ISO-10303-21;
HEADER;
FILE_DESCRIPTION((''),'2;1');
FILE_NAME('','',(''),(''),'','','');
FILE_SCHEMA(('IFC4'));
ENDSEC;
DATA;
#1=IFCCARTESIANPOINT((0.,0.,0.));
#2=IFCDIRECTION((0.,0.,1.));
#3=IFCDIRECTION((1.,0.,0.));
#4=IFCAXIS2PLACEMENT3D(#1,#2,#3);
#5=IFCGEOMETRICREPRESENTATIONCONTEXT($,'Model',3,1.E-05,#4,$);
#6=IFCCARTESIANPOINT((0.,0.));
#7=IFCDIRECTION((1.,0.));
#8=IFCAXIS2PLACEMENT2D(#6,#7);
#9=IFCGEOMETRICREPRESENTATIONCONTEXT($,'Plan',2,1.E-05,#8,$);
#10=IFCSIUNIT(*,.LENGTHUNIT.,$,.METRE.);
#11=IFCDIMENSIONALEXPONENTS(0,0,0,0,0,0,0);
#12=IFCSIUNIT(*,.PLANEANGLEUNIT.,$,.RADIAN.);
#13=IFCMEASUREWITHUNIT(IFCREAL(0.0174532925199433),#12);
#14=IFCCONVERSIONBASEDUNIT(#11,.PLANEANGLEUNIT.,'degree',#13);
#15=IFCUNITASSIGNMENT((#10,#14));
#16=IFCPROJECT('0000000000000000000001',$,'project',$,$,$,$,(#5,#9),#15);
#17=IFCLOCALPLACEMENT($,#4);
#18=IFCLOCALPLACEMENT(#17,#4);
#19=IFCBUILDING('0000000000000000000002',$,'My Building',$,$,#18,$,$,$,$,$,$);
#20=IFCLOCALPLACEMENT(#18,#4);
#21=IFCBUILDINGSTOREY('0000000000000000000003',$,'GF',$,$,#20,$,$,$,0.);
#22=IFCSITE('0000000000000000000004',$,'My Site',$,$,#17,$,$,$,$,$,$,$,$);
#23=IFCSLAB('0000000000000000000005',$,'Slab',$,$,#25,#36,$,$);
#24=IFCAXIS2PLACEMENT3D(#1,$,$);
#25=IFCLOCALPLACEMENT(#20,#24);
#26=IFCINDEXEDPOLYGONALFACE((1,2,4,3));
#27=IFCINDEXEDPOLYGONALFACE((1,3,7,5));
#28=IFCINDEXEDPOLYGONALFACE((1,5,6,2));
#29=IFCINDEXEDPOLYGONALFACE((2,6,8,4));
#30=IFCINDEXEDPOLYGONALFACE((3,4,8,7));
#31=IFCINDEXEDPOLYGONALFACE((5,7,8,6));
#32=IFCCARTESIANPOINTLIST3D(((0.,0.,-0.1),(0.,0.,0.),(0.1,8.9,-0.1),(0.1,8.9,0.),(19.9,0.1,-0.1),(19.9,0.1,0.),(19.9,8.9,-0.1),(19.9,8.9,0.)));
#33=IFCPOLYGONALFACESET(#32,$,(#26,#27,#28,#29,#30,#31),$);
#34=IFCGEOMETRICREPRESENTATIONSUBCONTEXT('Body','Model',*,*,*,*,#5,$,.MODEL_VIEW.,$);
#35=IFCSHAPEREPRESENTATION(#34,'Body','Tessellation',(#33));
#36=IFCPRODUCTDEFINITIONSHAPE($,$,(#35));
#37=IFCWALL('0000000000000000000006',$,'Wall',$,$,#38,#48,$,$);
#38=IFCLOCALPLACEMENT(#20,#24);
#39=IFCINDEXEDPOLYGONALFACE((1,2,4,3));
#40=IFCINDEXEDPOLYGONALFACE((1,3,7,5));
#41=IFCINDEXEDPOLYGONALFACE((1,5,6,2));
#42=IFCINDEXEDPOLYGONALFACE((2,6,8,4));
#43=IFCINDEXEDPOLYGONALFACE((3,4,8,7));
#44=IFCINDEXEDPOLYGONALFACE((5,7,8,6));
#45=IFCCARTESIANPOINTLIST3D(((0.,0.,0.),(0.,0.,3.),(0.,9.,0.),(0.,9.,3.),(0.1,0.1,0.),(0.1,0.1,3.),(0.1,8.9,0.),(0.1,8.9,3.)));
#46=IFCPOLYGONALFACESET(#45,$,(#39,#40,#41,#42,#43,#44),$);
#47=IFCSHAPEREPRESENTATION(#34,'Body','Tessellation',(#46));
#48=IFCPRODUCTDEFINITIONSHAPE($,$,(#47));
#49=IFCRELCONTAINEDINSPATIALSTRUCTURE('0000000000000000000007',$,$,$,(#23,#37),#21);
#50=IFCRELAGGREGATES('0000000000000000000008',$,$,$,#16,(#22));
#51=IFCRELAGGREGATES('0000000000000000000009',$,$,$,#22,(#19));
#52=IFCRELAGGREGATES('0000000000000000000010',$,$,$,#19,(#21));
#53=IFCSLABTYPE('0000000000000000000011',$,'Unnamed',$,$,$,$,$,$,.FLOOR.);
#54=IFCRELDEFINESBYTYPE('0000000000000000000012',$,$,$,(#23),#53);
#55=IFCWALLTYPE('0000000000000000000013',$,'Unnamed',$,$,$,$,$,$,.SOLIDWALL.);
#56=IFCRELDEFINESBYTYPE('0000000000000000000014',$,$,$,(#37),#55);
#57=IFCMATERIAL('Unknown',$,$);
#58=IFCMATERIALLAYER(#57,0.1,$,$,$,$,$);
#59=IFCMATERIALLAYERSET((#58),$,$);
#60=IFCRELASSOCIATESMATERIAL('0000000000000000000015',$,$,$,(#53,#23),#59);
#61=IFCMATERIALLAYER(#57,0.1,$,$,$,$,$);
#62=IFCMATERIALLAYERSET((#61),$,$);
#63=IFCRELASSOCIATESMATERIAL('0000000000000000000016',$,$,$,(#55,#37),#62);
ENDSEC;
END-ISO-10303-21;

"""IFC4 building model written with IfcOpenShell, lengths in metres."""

from ifc_helpers import new_model, entity, si_unit, converted_unit, frame, origin_with_axes, origin_2d_with_axis, place, context, subcontext, project, spatial, line, indexed_curve, outline, extrude, material, layer, layer_set, layer_usage, type_object, element, save


model = new_model("IFC4")

# Units and contexts
model_context = context("Model", 3, precision=1e-05, world=origin_with_axes())
plan_context = context("Plan", 2, precision=1e-05, world=origin_2d_with_axis())
body_context_1 = subcontext(model_context, "Body", "Model", "MODEL_VIEW")
ifc_project = project(units=[si_unit("LENGTHUNIT", "METRE"), converted_unit("PLANEANGLEUNIT", "degree", entity("IfcReal", 0.0174532925199433), si_unit("PLANEANGLEUNIT", "RADIAN"), dimensions=[0, 0, 0, 0, 0, 0, 0])], contexts=[model_context, plan_context])

# Site, building, storey
site_placement = place(None, origin_with_axes())
site = spatial("IfcSite", under=ifc_project, at=site_placement, Name="My Site")
building_placement = place(site_placement, origin_with_axes())
building = spatial("IfcBuilding", under=site, at=building_placement, Name="My Building")
storey_placement = place(building_placement, origin_with_axes())
storey = spatial("IfcBuildingStorey", under=building, at=storey_placement, Name="GF", Elevation=0.0)

# Slab
ifc_material = material(Name="Unknown")
ifc_layer_1 = layer(ifc_material, 0.1)
ifc_layer_set_1 = layer_set([ifc_layer_1])
ifc_layer_usage_1 = layer_usage(ifc_layer_set_1, "AXIS3", "POSITIVE", -0.1)
slab_type = type_object("IfcSlabType", Name="Unnamed", PredefinedType="FLOOR", material=ifc_layer_set_1)
slab_placement = place(storey_placement, frame((0.1, 8.9, 0.0), z_axis=(0.0, 0.0, 1.0), x_axis=(1.0, 0.0, 0.0)))
element("IfcSlab", 1, at=slab_placement, inside=storey, type_object=slab_type, material=ifc_layer_usage_1, Name="Slab", context=body_context_1, shape_type="SweptSolid", body=[
    extrude(outline(indexed_curve([(0.0, 0.0), (19.8, 0.0), (19.8, -8.8), (-0.1, -8.9), (0.0, 0.0)])), frame((0.0, 0.0, -0.1), z_axis=(0.0, 0.0, 1.0), x_axis=(1.0, 0.0, 0.0)), (0.0, 0.0, 1.0), 0.1),
])

# Shared definitions
ifc_layer_2 = layer(ifc_material, 0.1)
ifc_layer_set_2 = layer_set([ifc_layer_2])
wall_type = type_object("IfcWallType", Name="Unnamed", PredefinedType="SOLIDWALL", material=ifc_layer_set_2)

# Wall
ifc_layer_usage_2 = layer_usage(ifc_layer_set_2, "AXIS2", "POSITIVE", 0.0)
wall_1_placement = place(storey_placement, frame((0.0, 9.0, 0.0), z_axis=(0.0, 0.0, 1.0), x_axis=(0.0, -1.0, 0.0)))
element("IfcWall", 2, at=wall_1_placement, inside=storey, type_object=wall_type, material=ifc_layer_usage_2, Name="Wall", context=body_context_1, shape_type="SweptSolid", body=[
    extrude(outline(indexed_curve([(0.0, 0.0), (0.1, 0.1), (8.9, 0.1), (9.0, 0.0)], segments=[line(1, 2, 3, 4, 1)])), origin_with_axes(), (0.0, 0.0, 1.0), 3.0),
])

save(model, "model.ifc")
